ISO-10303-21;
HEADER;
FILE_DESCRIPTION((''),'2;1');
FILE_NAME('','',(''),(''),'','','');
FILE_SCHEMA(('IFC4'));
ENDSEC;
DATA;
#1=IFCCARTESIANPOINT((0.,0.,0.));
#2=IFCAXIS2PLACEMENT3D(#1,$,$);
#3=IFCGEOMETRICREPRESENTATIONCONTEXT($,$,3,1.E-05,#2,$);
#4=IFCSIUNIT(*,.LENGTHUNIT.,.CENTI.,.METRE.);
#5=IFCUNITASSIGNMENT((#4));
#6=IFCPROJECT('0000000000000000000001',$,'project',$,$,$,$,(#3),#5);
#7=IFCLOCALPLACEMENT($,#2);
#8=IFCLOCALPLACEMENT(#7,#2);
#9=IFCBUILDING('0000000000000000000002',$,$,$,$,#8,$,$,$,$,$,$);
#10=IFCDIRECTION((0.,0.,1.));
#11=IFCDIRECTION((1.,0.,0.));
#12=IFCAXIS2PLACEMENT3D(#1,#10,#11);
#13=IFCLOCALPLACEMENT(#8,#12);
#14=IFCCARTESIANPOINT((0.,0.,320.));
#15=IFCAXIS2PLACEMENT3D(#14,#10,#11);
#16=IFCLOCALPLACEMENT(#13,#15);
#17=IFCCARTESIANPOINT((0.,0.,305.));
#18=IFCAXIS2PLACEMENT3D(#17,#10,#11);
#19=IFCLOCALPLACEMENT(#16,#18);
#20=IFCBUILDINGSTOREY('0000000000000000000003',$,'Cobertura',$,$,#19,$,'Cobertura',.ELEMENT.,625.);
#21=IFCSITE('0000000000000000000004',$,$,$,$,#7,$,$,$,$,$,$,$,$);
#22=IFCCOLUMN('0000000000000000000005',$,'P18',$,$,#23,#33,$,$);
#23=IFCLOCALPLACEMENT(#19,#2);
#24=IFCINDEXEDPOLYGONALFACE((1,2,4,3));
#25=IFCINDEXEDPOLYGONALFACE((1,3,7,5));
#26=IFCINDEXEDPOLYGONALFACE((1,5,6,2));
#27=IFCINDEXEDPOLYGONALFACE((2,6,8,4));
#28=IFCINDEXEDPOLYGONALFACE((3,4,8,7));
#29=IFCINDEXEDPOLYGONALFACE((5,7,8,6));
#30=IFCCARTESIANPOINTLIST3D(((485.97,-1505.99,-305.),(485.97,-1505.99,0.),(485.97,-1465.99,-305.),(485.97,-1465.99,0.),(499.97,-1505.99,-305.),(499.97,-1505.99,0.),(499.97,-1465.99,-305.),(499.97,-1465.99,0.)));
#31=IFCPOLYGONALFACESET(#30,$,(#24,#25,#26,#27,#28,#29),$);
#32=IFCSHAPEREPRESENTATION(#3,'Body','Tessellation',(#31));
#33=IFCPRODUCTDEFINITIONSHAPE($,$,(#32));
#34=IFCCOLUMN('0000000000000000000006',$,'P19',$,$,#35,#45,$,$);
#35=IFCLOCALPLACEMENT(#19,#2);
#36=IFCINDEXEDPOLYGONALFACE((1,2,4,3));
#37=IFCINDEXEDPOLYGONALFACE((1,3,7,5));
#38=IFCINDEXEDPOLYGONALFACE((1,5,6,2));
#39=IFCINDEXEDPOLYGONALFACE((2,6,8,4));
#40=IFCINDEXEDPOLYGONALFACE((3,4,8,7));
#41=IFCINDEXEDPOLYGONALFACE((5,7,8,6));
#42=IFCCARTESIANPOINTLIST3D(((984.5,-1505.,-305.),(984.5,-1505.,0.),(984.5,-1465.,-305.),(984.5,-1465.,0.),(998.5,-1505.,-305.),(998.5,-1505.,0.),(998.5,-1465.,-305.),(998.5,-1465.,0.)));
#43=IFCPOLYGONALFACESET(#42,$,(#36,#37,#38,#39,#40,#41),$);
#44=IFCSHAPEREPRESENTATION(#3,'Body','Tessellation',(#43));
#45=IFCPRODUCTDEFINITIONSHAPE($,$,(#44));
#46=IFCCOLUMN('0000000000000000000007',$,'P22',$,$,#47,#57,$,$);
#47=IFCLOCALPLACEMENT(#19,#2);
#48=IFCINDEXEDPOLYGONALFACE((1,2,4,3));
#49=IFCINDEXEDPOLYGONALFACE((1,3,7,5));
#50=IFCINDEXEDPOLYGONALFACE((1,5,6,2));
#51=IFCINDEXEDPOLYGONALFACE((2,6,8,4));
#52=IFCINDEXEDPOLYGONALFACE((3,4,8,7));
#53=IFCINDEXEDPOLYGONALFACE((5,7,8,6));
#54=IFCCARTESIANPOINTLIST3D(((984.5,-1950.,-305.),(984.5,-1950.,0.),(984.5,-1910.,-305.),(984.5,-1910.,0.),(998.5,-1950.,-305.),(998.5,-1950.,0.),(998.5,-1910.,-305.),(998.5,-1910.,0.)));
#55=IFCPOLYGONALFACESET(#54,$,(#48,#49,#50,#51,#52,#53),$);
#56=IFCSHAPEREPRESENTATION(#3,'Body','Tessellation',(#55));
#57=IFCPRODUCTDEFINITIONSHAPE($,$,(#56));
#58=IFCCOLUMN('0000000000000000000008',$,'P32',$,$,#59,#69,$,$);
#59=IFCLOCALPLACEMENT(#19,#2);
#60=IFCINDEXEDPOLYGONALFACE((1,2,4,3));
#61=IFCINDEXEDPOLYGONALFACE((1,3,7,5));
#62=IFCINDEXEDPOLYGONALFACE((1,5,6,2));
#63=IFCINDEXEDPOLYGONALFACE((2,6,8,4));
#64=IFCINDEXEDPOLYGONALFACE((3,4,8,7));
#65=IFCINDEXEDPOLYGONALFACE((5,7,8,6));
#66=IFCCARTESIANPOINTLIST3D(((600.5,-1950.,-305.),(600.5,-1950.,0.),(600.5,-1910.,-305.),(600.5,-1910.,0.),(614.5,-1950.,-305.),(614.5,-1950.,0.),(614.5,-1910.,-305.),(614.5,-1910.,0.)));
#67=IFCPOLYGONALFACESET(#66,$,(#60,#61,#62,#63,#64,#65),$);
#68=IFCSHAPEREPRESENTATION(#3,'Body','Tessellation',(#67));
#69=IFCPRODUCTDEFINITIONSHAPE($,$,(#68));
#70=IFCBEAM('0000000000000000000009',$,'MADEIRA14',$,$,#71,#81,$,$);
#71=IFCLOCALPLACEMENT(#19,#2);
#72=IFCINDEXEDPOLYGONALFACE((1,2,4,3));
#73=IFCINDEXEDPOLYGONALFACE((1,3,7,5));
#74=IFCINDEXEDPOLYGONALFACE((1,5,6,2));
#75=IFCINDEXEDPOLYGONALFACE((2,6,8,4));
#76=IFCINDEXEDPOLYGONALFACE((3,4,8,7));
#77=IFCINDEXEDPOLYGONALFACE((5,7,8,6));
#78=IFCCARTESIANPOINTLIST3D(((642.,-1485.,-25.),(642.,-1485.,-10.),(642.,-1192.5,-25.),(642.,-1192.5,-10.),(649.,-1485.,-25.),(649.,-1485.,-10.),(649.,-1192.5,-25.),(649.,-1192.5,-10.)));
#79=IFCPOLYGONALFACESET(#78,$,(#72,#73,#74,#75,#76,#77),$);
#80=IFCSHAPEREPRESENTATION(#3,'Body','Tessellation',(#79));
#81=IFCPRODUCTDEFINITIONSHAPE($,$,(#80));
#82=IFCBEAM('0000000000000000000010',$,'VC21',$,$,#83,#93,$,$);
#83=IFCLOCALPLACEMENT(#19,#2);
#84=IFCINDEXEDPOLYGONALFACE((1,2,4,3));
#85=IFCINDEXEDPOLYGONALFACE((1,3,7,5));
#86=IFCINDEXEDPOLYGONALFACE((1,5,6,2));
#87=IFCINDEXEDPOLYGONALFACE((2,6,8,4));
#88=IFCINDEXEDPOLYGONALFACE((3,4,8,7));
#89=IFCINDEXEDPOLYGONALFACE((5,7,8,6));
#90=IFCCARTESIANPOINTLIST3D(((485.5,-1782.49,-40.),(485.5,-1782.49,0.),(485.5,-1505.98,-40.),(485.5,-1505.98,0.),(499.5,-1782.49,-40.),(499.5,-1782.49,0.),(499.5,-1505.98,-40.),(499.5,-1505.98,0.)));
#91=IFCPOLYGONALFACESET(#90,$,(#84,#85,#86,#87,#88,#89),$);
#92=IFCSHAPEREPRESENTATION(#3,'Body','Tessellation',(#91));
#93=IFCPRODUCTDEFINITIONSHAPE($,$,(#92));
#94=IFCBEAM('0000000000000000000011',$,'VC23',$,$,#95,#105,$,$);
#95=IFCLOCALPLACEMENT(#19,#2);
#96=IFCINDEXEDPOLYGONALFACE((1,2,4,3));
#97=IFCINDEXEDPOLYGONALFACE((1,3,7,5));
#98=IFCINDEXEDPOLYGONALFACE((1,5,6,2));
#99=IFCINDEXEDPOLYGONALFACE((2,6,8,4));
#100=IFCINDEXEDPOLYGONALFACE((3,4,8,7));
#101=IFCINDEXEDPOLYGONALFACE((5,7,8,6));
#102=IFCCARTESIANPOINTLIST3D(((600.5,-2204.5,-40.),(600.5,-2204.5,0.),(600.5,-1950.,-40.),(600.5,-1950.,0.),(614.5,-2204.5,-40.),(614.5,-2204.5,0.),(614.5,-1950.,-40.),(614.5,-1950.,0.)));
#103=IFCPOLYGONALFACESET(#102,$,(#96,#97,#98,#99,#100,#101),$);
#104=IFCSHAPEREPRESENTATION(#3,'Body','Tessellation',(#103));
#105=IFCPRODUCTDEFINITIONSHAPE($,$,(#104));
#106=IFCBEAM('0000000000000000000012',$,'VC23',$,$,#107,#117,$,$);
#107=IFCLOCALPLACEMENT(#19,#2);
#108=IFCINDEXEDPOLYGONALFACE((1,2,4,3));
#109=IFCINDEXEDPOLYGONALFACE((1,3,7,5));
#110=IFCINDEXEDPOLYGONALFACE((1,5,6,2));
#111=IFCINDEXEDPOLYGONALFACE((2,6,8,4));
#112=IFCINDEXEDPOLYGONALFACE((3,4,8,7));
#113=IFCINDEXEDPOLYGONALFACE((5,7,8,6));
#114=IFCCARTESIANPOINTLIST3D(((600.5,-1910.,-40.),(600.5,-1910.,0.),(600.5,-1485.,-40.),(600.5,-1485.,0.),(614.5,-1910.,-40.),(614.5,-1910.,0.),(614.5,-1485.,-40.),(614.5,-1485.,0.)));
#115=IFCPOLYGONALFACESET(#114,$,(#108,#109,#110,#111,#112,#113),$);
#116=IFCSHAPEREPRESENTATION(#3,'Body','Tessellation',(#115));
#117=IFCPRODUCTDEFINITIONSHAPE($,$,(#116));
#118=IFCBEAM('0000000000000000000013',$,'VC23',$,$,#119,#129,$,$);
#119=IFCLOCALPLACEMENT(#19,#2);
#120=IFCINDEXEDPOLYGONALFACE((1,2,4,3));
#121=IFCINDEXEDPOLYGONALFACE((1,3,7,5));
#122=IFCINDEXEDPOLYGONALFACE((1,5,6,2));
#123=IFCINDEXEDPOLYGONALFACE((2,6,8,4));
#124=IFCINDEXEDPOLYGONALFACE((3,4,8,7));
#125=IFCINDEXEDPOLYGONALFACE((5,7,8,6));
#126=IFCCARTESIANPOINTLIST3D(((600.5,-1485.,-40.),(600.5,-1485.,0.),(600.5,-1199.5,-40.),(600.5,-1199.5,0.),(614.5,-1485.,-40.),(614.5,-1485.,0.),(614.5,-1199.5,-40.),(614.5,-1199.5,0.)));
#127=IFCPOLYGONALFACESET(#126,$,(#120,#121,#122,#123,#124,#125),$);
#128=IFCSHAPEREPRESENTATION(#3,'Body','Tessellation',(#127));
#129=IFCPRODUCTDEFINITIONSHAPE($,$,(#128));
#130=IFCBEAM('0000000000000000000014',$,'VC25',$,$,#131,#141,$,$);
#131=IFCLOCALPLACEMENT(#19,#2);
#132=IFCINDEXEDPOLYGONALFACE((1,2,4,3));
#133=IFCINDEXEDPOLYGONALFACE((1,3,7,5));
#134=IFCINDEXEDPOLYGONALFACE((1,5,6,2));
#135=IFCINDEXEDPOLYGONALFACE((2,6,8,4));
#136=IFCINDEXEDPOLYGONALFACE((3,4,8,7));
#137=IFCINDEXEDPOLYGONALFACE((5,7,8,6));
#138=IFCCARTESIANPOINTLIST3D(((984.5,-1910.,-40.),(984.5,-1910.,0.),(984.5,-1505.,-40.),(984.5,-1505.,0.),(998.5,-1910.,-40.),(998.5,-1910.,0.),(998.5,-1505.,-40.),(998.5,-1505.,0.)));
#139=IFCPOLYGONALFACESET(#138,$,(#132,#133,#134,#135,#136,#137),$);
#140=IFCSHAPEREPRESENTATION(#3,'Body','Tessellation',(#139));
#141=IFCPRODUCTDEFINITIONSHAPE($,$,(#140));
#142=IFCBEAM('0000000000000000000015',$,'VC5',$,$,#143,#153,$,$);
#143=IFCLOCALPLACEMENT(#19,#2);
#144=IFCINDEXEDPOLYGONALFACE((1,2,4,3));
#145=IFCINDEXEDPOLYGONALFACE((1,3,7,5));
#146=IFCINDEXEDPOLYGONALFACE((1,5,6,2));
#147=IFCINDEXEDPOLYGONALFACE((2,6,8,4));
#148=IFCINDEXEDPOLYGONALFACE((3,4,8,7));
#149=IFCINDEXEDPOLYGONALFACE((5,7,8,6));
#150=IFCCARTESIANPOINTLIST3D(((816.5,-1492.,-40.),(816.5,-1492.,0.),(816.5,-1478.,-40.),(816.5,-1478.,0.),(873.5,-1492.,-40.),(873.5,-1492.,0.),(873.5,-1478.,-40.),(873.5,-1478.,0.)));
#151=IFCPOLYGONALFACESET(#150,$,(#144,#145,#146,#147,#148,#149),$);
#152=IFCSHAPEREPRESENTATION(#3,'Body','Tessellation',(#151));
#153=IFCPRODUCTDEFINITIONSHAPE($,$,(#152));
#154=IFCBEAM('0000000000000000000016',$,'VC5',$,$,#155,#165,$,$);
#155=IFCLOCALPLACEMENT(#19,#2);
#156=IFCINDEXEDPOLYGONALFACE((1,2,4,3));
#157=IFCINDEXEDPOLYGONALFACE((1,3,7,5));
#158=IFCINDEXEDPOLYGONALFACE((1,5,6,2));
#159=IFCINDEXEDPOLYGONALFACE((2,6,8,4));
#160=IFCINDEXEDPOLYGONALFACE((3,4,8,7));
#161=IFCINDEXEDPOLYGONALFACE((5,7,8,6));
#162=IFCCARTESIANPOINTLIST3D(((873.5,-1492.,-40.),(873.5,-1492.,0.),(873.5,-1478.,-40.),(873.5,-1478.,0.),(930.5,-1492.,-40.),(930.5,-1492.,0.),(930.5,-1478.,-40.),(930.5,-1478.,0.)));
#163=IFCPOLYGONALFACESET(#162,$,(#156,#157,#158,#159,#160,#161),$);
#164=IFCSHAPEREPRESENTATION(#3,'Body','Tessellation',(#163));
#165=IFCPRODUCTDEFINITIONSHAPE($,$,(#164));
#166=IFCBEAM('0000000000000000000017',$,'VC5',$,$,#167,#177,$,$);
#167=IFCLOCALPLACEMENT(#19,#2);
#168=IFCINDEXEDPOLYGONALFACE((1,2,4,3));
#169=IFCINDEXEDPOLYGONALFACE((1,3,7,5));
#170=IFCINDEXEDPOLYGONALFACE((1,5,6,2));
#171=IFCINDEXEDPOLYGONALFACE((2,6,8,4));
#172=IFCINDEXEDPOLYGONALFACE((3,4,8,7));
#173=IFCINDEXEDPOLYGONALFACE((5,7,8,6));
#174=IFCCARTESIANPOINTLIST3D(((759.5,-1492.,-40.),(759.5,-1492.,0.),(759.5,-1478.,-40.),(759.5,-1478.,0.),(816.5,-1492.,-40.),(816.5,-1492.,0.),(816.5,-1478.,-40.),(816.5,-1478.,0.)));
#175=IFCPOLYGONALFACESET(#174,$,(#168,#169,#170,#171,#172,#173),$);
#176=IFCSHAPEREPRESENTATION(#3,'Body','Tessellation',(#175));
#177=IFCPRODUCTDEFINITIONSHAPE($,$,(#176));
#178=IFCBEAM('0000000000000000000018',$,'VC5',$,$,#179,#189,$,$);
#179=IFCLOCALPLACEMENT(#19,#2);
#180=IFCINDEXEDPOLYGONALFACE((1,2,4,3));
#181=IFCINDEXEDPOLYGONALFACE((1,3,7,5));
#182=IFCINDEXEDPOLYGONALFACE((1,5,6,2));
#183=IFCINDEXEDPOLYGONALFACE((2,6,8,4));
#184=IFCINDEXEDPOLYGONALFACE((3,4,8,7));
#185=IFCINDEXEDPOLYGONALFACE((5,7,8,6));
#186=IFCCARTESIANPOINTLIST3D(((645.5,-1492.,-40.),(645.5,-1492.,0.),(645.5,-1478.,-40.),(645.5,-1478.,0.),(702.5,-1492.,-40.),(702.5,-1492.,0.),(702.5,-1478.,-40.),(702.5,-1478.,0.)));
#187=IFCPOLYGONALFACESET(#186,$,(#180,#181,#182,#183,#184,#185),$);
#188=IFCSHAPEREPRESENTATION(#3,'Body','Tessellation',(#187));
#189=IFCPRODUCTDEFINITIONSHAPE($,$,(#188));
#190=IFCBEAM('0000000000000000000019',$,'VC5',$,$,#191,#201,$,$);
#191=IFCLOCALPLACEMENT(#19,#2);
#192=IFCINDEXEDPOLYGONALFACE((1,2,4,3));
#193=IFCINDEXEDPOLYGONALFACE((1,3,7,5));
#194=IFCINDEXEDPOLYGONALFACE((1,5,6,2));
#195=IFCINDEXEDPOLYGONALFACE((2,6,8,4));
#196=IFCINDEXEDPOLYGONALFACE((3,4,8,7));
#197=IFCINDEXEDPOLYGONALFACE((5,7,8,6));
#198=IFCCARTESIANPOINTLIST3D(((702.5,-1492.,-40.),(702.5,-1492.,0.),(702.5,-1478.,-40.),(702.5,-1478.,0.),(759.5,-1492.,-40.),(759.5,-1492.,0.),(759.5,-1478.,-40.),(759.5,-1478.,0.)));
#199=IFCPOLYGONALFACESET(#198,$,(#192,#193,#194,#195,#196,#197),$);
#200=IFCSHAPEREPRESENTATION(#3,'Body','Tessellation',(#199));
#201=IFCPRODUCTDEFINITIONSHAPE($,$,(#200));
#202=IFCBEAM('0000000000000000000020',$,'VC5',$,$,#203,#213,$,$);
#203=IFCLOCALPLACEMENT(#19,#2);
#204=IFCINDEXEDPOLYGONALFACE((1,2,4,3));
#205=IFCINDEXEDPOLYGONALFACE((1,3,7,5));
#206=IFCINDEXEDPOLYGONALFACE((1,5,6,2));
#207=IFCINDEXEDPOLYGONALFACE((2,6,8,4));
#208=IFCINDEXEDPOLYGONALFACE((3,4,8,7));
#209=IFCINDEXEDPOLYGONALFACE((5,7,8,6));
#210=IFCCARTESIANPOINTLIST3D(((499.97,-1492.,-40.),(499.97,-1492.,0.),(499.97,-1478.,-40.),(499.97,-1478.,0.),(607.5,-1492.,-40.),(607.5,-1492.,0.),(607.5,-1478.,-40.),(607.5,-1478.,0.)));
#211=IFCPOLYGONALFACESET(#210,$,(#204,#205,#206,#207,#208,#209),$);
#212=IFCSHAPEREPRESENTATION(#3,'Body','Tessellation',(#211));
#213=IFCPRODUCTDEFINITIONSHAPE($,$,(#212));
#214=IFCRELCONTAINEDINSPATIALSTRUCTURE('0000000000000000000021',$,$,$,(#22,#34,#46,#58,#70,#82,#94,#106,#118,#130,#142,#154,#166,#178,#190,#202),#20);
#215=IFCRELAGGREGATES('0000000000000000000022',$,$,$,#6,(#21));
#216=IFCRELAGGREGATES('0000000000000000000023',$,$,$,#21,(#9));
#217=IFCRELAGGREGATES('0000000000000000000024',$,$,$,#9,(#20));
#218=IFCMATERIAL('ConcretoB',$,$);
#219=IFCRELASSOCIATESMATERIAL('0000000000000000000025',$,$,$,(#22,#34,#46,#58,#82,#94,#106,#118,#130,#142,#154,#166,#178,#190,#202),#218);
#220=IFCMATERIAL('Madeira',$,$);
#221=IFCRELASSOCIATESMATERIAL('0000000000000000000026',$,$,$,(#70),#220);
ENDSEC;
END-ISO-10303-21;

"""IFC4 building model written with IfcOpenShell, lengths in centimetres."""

from ifc_helpers import new_model, si_unit, frame, origin, origin_with_axes, place, context, project, spatial, polyline, outline, extrude, material, element, save


model = new_model("IFC4")

# Units and contexts
context_of_model = context(None, 3, precision=1e-05, world=origin())
ifc_project = project(units=[si_unit("LENGTHUNIT", "METRE", prefix="CENTI")], contexts=[context_of_model])

# Site, building, storey
site_placement = place(None, origin())
site = spatial("IfcSite", under=ifc_project, at=site_placement)
building_placement = place(site_placement, origin())
building = spatial("IfcBuilding", under=site, at=building_placement)
placement_1 = place(building_placement, origin_with_axes())
placement_2 = place(placement_1, frame((0.0, 0.0, 320.0), z_axis=(0.0, 0.0, 1.0), x_axis=(1.0, 0.0, 0.0)))
storey_placement = place(placement_2, frame((0.0, 0.0, 305.0), z_axis=(0.0, 0.0, 1.0), x_axis=(1.0, 0.0, 0.0)))
storey = spatial("IfcBuildingStorey", under=building, at=storey_placement, Name="Cobertura", LongName="Cobertura", CompositionType="ELEMENT", Elevation=625.0)

# Columns
ifc_material_1 = material(Name="ConcretoB")
column_1_placement = place(storey_placement, frame((492.97, -1485.99, 0.0), z_axis=(0.0, 0.0, 1.0), x_axis=(1.0, 0.0, 0.0)))
element("IfcColumn", 1, at=column_1_placement, inside=storey, material=ifc_material_1, Name="P18", context=context_of_model, shape_type="SolidModel", body=[
    extrude(outline(polyline([(-7.0, -20.0), (7.0, -20.0), (7.0, 20.0), (-7.0, 20.0), (-7.0, -20.0)])), origin_with_axes(), (0.0, 0.0, -1.0), 305.0),
])
for number, where, z_axis, x_axis, name in (
    (2, (991.5, -1485.0, 0.0), (0.0, 0.0, 1.0), (1.0, 0.0, 0.0), "P19"),
    (3, (991.5, -1930.0, 0.0), (0.0, 0.0, 1.0), (1.0, 0.0, 0.0), "P22"),
):
    element("IfcColumn", number, at=place(storey_placement, frame(where, z_axis=z_axis, x_axis=x_axis)), inside=storey, material=ifc_material_1, Name=name, context=context_of_model, shape_type="SolidModel", body=[
        extrude(outline(polyline([(7.0, 20.0), (-7.0, 20.0), (-7.0, -20.0), (7.0, -20.0), (7.0, 20.0)])), origin_with_axes(), (0.0, 0.0, -1.0), 305.0),
    ])
column_2_placement = place(storey_placement, frame((607.5, -1930.0, 0.0), z_axis=(0.0, 0.0, 1.0), x_axis=(1.0, 0.0, 0.0)))
element("IfcColumn", 4, at=column_2_placement, inside=storey, material=ifc_material_1, Name="P32", context=context_of_model, shape_type="SolidModel", body=[
    extrude(outline(polyline([(-7.0, -20.0), (7.0, -20.0), (7.0, 20.0), (-7.0, 20.0), (-7.0, -20.0)])), origin_with_axes(), (0.0, 0.0, -1.0), 305.0),
])

# Beams
ifc_material_2 = material(Name="Madeira")
beam_1_placement = place(storey_placement, frame((645.5, -1338.75, -10.0), z_axis=(0.0, 0.0, 1.0), x_axis=(1.0, 0.0, 0.0)))
element("IfcBeam", 5, at=beam_1_placement, inside=storey, material=ifc_material_2, Name="MADEIRA14", context=context_of_model, shape_type="SolidModel", body=[
    extrude(outline(polyline([(-3.5, -7.5), (-3.5, 7.5), (3.5, 7.5), (3.5, -7.5), (-3.5, -7.5)])), frame((0.0, -146.25, -7.5), z_axis=(0.0, 1.0, 0.0), x_axis=(1.0, 0.0, 0.0)), (0.0, 0.0, 1.0), 292.5),
])
beam_2_placement = place(storey_placement, frame((492.5, -1644.24, 0.0), z_axis=(0.0, 0.0, 1.0), x_axis=(1.0, 0.0, 0.0)))
element("IfcBeam", 6, at=beam_2_placement, inside=storey, material=ifc_material_1, Name="VC21", context=context_of_model, shape_type="SolidModel", body=[
    extrude(outline(polyline([(-7.0, -20.0), (7.0, -20.0), (7.0, 20.0), (-7.0, 20.0), (-7.0, -20.0)])), frame((0.0, -138.25, -20.0), z_axis=(0.0, 1.0, 0.0), x_axis=(1.0, 0.0, 0.0)), (0.0, 0.0, 1.0), 276.51),
])
beam_3_placement = place(storey_placement, frame((607.5, -2077.25, 0.0), z_axis=(0.0, 0.0, 1.0), x_axis=(1.0, 0.0, 0.0)))
element("IfcBeam", 7, at=beam_3_placement, inside=storey, material=ifc_material_1, Name="VC23", context=context_of_model, shape_type="SolidModel", body=[
    extrude(outline(polyline([(-7.0, -20.0), (7.0, -20.0), (7.0, 20.0), (-7.0, 20.0), (-7.0, -20.0)])), frame((0.0, -127.25, -20.0), z_axis=(0.0, 1.0, 0.0), x_axis=(1.0, 0.0, 0.0)), (0.0, 0.0, 1.0), 254.5),
])
beam_4_placement = place(storey_placement, frame((607.5, -1697.5, 0.0), z_axis=(0.0, 0.0, 1.0), x_axis=(1.0, 0.0, 0.0)))
element("IfcBeam", 8, at=beam_4_placement, inside=storey, material=ifc_material_1, Name="VC23", context=context_of_model, shape_type="SolidModel", body=[
    extrude(outline(polyline([(-7.0, -20.0), (7.0, -20.0), (7.0, 20.0), (-7.0, 20.0), (-7.0, -20.0)])), frame((0.0, -212.5, -20.0), z_axis=(0.0, 1.0, 0.0), x_axis=(1.0, 0.0, 0.0)), (0.0, 0.0, 1.0), 425.0),
])
beam_5_placement = place(storey_placement, frame((607.5, -1342.25, 0.0), z_axis=(0.0, 0.0, 1.0), x_axis=(1.0, 0.0, 0.0)))
element("IfcBeam", 9, at=beam_5_placement, inside=storey, material=ifc_material_1, Name="VC23", context=context_of_model, shape_type="SolidModel", body=[
    extrude(outline(polyline([(-7.0, -20.0), (7.0, -20.0), (7.0, 20.0), (-7.0, 20.0), (-7.0, -20.0)])), frame((0.0, -142.75, -20.0), z_axis=(0.0, 1.0, 0.0), x_axis=(1.0, 0.0, 0.0)), (0.0, 0.0, 1.0), 285.5),
])
beam_6_placement = place(storey_placement, frame((991.5, -1707.5, 0.0), z_axis=(0.0, 0.0, 1.0), x_axis=(1.0, 0.0, 0.0)))
element("IfcBeam", 10, at=beam_6_placement, inside=storey, material=ifc_material_1, Name="VC25", context=context_of_model, shape_type="SolidModel", body=[
    extrude(outline(polyline([(-7.0, -20.0), (7.0, -20.0), (7.0, 20.0), (-7.0, 20.0), (-7.0, -20.0)])), frame((0.0, -202.5, -20.0), z_axis=(0.0, 1.0, 0.0), x_axis=(1.0, 0.0, 0.0)), (0.0, 0.0, 1.0), 405.0),
])
for number, where, z_axis, x_axis, name in (
    (11, (845.0, -1485.0, 0.0), (0.0, 0.0, 1.0), (1.0, 0.0, 0.0), "VC5"),
    (12, (902.0, -1485.0, 0.0), (0.0, 0.0, 1.0), (1.0, 0.0, 0.0), "VC5"),
    (13, (788.0, -1485.0, 0.0), (0.0, 0.0, 1.0), (1.0, 0.0, 0.0), "VC5"),
    (14, (674.0, -1485.0, 0.0), (0.0, 0.0, 1.0), (1.0, 0.0, 0.0), "VC5"),
    (15, (731.0, -1485.0, 0.0), (0.0, 0.0, 1.0), (1.0, 0.0, 0.0), "VC5"),
):
    element("IfcBeam", number, at=place(storey_placement, frame(where, z_axis=z_axis, x_axis=x_axis)), inside=storey, material=ifc_material_1, Name=name, context=context_of_model, shape_type="SolidModel", body=[
        extrude(outline(polyline([(-7.0, -20.0), (7.0, -20.0), (7.0, 20.0), (-7.0, 20.0), (-7.0, -20.0)])), frame((-28.5, 0.0, -20.0), z_axis=(1.0, 0.0, 0.0), x_axis=(0.0, -1.0, 0.0)), (0.0, 0.0, 1.0), 57.0),
    ])
beam_7_placement = place(storey_placement, frame((553.74, -1485.0, 0.0), z_axis=(0.0, 0.0, 1.0), x_axis=(1.0, 0.0, 0.0)))
element("IfcBeam", 16, at=beam_7_placement, inside=storey, material=ifc_material_1, Name="VC5", context=context_of_model, shape_type="SolidModel", body=[
    extrude(outline(polyline([(-7.0, -20.0), (7.0, -20.0), (7.0, 20.0), (-7.0, 20.0), (-7.0, -20.0)])), frame((-53.77, 0.0, -20.0), z_axis=(1.0, 0.0, 0.0), x_axis=(0.0, -1.0, 0.0)), (0.0, 0.0, 1.0), 107.53),
])

save(model, "model.ifc")
